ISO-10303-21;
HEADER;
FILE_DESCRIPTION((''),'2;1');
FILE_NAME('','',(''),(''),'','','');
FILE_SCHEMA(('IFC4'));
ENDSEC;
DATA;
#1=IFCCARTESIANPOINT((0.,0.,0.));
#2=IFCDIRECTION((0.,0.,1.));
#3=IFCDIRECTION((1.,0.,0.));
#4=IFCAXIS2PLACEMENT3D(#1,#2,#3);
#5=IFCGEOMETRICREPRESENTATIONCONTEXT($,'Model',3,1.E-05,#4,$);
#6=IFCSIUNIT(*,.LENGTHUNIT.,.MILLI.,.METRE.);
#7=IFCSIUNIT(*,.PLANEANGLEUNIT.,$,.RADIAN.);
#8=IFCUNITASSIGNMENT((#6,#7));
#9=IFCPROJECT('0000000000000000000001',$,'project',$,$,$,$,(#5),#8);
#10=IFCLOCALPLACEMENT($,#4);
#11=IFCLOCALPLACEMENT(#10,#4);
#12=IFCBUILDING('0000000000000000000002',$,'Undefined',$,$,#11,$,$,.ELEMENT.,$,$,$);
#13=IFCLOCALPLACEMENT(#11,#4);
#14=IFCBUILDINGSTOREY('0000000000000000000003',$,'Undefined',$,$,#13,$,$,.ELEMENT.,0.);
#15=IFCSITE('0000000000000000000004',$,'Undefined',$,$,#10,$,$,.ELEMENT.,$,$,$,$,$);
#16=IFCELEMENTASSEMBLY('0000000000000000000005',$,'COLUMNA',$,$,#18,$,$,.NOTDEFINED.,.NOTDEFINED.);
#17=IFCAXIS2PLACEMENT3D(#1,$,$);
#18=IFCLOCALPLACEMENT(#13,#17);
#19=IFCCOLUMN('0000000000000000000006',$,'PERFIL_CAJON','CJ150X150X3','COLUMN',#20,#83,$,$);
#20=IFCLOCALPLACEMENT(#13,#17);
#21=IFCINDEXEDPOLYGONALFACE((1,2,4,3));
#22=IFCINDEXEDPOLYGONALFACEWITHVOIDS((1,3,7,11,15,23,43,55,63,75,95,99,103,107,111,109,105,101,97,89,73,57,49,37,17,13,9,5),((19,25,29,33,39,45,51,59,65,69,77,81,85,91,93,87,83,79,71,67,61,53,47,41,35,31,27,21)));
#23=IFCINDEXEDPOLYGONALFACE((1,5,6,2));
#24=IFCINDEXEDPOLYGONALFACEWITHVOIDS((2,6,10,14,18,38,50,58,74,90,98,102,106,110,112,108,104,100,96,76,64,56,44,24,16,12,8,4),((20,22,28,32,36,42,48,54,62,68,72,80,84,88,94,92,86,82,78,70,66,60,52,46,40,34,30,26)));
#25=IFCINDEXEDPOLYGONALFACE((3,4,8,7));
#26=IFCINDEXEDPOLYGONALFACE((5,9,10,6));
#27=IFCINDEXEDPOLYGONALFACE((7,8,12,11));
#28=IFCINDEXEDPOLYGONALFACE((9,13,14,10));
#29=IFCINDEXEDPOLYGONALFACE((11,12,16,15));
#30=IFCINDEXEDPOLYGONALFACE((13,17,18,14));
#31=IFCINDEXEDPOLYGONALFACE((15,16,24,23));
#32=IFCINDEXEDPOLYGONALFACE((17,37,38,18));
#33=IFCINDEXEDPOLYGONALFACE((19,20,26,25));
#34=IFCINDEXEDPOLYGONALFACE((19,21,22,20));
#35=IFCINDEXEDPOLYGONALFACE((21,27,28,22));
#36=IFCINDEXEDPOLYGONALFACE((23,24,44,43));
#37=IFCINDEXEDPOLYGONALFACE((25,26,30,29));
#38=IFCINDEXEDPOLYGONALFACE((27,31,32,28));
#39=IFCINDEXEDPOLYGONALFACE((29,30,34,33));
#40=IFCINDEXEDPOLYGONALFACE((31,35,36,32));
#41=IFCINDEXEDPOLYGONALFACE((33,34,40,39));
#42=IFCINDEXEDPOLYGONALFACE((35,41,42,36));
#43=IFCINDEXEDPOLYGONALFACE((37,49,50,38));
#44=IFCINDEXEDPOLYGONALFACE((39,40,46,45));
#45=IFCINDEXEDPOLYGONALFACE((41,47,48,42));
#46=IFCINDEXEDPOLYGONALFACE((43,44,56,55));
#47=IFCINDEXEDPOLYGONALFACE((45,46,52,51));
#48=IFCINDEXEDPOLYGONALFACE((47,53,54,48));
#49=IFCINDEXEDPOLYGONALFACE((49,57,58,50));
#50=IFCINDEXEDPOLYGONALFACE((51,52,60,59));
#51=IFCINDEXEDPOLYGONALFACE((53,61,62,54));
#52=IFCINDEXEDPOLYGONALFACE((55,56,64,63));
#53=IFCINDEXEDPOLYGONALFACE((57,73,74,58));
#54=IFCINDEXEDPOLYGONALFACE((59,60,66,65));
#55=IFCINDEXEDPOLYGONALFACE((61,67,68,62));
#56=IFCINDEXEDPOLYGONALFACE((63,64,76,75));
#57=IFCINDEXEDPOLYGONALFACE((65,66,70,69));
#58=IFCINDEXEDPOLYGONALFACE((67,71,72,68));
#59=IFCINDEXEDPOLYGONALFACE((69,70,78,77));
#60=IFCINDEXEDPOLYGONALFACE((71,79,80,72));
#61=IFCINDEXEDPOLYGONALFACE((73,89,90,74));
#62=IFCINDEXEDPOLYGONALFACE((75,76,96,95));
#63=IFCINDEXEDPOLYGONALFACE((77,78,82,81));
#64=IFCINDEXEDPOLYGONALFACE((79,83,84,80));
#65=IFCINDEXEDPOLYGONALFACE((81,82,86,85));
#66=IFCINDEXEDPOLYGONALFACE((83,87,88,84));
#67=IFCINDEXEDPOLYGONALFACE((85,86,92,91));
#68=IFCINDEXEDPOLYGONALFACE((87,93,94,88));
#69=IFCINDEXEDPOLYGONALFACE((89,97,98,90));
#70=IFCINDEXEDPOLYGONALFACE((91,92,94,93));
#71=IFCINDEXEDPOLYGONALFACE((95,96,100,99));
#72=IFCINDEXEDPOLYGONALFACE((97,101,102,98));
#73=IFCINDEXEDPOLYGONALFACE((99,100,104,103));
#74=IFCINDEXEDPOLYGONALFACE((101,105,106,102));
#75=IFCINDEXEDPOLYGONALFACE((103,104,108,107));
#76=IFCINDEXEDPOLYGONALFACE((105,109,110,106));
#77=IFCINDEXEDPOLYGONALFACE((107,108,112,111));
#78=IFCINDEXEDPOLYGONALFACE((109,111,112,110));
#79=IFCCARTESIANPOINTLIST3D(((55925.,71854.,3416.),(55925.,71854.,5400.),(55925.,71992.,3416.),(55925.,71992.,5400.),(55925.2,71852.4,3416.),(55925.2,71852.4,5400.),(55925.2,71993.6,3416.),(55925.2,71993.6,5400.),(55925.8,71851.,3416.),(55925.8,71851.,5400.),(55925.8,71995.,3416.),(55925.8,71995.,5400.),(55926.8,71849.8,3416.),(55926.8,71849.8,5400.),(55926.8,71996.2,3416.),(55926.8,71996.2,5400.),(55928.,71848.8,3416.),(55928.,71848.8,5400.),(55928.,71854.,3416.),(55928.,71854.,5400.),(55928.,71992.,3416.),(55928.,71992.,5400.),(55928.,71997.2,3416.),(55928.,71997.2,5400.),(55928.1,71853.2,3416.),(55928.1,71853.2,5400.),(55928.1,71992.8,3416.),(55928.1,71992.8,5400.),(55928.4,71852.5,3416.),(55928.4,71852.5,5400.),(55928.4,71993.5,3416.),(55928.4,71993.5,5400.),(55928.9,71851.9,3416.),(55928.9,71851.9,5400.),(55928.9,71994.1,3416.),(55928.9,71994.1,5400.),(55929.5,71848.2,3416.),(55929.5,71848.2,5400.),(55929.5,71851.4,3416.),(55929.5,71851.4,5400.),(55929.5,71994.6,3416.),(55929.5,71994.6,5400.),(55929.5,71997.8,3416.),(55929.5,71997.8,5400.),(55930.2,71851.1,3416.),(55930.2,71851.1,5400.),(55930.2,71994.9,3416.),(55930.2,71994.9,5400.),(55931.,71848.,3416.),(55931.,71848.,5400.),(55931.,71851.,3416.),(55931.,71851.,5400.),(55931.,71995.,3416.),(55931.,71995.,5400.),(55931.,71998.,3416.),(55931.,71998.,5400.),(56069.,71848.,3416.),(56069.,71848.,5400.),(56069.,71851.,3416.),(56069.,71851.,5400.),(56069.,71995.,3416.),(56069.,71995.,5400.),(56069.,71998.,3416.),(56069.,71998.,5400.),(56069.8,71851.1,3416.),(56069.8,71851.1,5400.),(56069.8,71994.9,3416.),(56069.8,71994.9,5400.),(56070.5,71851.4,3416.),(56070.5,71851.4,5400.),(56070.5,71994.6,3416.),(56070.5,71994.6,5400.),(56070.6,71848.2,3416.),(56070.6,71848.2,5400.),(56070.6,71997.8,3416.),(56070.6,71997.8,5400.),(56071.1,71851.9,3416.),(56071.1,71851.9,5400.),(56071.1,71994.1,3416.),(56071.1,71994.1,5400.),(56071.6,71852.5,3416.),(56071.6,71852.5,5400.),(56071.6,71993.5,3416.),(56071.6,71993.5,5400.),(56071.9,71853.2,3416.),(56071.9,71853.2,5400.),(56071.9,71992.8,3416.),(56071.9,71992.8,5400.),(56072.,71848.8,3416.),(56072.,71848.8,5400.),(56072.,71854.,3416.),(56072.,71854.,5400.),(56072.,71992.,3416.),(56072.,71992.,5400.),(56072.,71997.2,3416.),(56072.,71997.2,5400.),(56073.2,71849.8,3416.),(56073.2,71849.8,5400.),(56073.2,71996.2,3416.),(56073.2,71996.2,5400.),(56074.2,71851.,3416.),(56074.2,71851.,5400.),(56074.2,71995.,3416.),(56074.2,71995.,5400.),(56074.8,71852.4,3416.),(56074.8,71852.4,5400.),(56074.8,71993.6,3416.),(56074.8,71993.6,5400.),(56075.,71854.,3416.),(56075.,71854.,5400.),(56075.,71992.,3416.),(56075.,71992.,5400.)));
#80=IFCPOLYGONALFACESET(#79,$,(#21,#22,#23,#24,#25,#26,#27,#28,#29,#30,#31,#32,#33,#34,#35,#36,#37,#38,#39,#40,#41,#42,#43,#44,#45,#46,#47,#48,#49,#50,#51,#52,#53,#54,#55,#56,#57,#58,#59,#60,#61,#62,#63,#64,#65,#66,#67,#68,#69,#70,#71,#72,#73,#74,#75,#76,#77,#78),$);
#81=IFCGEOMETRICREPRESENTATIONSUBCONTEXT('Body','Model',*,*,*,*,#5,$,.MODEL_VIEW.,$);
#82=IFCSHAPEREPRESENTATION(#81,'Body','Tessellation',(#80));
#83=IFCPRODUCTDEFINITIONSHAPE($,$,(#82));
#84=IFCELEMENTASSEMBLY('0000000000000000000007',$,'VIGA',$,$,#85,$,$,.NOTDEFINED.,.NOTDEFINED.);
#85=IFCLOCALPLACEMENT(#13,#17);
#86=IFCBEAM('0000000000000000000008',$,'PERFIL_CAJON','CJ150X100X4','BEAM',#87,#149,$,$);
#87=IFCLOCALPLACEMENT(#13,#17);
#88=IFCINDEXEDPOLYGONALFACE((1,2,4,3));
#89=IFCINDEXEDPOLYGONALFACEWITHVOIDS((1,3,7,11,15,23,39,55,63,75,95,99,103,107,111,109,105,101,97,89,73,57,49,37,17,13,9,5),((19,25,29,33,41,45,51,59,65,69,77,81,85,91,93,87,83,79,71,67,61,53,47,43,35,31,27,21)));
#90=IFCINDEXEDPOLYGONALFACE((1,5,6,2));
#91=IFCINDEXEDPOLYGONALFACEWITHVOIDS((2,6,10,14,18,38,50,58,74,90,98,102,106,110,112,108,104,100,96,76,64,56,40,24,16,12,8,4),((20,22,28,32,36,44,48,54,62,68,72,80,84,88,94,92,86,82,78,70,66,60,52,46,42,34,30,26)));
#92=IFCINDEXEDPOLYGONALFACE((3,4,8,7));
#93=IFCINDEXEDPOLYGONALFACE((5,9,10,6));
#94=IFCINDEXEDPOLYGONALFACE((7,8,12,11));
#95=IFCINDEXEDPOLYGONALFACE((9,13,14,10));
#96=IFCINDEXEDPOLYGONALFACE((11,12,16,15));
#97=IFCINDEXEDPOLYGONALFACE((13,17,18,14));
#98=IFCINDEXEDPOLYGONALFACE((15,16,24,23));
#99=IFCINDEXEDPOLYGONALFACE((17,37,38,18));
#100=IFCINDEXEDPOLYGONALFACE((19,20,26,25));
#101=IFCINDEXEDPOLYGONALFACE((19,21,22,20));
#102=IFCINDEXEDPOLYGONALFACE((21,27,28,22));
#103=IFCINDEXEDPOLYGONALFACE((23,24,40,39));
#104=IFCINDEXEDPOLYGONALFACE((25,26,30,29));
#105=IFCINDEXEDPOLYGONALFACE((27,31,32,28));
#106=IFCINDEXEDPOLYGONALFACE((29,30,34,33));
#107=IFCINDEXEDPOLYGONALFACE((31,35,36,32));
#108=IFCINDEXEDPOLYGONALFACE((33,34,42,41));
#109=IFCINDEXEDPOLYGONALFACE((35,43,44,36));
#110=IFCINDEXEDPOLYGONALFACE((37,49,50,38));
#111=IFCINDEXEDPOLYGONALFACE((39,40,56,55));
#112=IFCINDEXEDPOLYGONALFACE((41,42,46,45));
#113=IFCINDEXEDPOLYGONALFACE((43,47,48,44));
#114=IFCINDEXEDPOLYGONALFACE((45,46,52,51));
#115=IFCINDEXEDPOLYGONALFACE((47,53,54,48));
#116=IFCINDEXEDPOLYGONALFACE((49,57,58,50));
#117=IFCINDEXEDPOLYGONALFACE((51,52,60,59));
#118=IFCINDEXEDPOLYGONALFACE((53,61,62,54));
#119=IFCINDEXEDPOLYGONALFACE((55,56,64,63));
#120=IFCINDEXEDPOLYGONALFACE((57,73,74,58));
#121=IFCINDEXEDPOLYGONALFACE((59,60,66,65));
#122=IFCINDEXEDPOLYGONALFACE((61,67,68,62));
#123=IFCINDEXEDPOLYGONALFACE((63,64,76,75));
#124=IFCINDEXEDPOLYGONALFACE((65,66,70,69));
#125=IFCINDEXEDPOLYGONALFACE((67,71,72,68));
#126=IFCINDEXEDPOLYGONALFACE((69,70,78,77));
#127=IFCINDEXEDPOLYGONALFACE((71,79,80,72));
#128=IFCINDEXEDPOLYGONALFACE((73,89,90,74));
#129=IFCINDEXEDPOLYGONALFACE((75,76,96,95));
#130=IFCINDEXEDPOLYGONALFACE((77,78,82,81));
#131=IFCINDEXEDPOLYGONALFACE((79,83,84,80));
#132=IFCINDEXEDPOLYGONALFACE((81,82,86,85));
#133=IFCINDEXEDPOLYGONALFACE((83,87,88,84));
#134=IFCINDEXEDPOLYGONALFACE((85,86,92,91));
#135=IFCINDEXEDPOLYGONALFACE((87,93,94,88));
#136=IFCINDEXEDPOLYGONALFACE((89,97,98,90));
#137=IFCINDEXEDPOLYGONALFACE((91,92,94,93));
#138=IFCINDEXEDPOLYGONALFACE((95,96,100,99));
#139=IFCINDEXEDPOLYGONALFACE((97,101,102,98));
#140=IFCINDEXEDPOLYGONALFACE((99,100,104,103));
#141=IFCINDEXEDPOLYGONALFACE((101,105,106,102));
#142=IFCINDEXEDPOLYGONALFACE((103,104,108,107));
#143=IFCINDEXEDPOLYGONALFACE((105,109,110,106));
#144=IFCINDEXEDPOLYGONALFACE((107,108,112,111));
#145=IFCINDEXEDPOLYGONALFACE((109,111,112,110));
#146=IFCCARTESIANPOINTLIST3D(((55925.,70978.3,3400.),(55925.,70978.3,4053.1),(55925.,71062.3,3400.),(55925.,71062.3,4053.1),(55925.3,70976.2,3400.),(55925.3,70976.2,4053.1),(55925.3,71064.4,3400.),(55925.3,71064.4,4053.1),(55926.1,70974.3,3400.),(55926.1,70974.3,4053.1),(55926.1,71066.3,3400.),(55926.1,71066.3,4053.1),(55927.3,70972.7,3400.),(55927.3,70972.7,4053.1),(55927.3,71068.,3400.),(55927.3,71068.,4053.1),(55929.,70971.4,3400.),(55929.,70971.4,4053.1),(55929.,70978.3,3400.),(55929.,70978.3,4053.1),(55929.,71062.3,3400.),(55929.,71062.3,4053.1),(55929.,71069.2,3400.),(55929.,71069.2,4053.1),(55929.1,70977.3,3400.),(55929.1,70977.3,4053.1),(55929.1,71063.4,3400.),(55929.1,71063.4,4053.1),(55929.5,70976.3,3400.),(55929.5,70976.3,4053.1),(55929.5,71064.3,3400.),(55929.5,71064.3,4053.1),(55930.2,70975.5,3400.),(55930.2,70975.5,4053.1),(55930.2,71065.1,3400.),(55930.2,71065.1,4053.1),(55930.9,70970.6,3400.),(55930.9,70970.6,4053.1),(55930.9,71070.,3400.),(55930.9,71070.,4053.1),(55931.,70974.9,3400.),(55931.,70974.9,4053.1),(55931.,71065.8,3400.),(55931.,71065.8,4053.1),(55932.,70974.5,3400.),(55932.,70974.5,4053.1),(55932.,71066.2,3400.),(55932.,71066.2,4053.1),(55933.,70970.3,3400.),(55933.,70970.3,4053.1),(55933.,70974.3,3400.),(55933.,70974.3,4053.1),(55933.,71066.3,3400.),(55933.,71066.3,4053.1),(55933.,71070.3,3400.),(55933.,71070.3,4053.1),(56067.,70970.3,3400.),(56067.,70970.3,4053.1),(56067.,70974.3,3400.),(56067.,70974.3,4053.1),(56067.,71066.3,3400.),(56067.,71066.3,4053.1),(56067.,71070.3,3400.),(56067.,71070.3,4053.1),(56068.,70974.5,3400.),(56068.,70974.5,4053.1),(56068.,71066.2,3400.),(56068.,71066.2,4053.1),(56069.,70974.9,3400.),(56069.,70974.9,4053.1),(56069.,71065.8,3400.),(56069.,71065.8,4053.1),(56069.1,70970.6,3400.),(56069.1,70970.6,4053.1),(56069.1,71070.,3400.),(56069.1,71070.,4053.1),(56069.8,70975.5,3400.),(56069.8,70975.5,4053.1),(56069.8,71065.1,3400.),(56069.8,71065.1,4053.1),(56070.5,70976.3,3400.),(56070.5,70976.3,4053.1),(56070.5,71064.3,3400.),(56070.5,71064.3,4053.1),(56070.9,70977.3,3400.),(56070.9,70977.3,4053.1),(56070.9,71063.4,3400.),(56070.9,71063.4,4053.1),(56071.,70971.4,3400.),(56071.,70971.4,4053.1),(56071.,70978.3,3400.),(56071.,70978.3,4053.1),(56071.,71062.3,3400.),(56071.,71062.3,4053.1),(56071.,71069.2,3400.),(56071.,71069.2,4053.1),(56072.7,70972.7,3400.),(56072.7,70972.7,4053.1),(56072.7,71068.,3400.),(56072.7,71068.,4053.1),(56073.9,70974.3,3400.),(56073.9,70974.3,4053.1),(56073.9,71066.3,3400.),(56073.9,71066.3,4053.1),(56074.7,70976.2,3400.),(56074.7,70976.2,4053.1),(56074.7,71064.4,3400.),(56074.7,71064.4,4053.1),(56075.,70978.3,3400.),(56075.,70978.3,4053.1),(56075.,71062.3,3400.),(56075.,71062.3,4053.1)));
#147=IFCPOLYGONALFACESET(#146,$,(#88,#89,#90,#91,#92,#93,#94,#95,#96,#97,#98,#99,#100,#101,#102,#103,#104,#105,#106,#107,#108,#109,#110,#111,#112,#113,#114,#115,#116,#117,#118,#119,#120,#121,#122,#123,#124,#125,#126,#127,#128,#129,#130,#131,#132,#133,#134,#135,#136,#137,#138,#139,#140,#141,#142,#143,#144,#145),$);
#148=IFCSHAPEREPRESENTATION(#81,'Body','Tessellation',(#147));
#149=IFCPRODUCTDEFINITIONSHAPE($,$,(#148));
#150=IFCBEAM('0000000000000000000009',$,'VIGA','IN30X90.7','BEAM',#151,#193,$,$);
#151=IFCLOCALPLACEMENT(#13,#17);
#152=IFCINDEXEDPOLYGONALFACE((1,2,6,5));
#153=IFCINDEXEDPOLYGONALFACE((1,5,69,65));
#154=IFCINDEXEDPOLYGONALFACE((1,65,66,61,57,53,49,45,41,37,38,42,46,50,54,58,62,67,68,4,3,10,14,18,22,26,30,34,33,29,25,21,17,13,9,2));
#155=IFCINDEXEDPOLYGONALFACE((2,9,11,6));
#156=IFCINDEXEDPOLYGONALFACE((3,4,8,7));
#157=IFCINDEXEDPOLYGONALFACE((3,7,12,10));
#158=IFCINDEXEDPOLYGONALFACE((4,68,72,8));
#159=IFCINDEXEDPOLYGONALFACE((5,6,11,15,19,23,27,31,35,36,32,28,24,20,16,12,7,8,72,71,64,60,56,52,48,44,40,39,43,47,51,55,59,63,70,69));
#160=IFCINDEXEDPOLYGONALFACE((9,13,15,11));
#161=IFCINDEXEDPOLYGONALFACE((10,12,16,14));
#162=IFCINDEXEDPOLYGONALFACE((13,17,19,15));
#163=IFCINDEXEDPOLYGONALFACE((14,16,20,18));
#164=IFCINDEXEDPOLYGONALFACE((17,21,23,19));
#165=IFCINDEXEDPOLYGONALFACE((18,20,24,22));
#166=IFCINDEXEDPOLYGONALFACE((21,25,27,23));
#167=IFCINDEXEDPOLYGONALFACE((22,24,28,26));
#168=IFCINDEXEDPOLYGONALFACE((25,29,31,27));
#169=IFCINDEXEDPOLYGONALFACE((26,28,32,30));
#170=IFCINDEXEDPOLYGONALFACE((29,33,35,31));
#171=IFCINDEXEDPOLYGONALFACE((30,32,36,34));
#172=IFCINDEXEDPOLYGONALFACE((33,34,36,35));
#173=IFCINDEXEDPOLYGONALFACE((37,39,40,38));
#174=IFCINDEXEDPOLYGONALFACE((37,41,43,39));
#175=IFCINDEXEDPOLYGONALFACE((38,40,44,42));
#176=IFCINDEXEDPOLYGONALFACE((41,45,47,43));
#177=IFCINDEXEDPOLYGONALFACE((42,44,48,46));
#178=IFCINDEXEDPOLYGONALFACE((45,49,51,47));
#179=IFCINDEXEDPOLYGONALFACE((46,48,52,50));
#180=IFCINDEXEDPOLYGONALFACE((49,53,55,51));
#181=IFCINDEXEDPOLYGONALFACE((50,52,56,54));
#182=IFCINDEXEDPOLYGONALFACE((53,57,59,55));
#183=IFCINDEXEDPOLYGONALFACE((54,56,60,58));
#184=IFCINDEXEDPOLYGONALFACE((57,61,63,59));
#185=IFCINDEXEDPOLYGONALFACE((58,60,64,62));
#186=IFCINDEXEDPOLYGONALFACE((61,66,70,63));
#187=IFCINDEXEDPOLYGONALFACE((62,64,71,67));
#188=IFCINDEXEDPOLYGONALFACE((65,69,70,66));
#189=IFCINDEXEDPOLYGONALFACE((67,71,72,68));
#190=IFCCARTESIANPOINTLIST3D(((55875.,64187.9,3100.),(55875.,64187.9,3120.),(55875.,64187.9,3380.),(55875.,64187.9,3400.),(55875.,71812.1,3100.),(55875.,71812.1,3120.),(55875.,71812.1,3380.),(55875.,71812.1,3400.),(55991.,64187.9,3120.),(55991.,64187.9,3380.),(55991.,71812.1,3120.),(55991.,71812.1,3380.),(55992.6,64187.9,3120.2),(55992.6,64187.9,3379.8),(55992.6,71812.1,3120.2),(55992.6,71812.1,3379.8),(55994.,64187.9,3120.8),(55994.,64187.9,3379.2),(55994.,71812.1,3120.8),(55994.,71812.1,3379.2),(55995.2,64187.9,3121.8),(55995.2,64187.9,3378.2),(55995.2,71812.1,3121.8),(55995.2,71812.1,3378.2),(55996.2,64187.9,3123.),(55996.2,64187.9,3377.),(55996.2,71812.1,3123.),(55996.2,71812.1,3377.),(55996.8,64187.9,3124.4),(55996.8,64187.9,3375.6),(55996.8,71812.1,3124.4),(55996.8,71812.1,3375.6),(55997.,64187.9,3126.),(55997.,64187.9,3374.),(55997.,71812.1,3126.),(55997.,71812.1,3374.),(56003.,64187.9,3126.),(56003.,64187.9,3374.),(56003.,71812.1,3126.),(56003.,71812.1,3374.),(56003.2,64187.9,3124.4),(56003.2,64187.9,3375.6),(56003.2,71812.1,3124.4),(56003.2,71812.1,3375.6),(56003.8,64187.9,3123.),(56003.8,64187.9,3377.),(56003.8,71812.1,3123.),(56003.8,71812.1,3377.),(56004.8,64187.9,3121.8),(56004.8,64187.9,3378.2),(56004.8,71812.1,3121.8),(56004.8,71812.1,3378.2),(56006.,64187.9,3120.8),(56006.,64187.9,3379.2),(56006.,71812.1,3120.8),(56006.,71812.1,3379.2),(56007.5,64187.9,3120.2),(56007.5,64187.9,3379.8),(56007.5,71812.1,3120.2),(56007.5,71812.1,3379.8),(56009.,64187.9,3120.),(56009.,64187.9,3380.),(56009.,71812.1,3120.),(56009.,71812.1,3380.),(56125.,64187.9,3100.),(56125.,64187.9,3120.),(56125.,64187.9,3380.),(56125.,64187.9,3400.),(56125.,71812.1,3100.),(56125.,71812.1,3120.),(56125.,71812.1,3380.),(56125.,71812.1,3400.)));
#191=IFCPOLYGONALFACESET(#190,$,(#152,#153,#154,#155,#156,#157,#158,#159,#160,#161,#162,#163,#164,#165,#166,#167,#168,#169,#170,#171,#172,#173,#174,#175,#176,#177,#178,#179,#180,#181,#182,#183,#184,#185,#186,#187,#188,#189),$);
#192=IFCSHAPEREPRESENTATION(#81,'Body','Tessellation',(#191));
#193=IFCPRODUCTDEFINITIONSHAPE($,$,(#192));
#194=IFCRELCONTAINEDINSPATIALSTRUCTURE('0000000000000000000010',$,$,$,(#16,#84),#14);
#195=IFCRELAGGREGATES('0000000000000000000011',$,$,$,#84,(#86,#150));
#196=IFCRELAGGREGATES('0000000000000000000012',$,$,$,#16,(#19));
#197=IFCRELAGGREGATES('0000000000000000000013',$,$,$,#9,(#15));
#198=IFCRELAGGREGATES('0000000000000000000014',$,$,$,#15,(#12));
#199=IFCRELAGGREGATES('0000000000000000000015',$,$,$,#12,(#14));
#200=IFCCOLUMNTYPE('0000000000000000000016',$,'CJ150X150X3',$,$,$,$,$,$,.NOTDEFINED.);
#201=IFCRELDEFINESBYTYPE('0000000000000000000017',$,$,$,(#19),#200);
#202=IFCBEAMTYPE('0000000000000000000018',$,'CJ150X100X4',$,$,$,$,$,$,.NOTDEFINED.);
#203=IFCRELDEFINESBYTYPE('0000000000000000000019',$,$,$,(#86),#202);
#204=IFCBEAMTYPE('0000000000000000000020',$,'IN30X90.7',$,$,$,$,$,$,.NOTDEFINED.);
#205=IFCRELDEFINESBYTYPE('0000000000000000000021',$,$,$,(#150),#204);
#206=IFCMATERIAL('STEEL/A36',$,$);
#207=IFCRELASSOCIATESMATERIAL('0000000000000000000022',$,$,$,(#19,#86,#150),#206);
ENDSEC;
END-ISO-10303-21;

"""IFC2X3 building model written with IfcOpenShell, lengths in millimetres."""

from ifc_helpers import new_model, si_unit, frame, origin_with_axes, origin_2d_with_axis, place, context, subcontext, project, spatial, hollow_rectangle, i_section, extrude, material, type_object, element, aggregate, save


model = new_model("IFC2X3")

# Units and contexts
model_context = context("Model", 3, precision=1e-05, world=origin_with_axes())
body_context = subcontext(model_context, "Body", "Model", "MODEL_VIEW")
ifc_project = project(units=[si_unit("LENGTHUNIT", "METRE", prefix="MILLI"), si_unit("PLANEANGLEUNIT", "RADIAN")], contexts=[model_context])

# Site, building, storey
site_placement = place(None, origin_with_axes())
site = spatial("IfcSite", under=ifc_project, at=site_placement, Name="Undefined", CompositionType="ELEMENT")
building_placement = place(site_placement, origin_with_axes())
building = spatial("IfcBuilding", under=site, at=building_placement, Name="Undefined", CompositionType="ELEMENT")
storey_placement = place(building_placement, origin_with_axes())
storey = spatial("IfcBuildingStorey", under=building, at=storey_placement, Name="Undefined", CompositionType="ELEMENT", Elevation=0.0)

# Element assembly, column
assembly_1_placement = place(storey_placement, origin_with_axes())
assembly_1 = element("IfcElementAssembly", 1, at=assembly_1_placement, inside=storey, Name="COLUMNA", AssemblyPlace="NOTDEFINED", PredefinedType="NOTDEFINED")
ifc_material_1 = material(Name="STEEL/A36")
column_type = type_object("IfcColumnType", Name="CJ150X150X3", PredefinedType="NOTDEFINED")
column_placement = place(assembly_1_placement, frame((56000.0, 71923.0, 3416.0), z_axis=(0.0, 0.0, 1.0), x_axis=(-1.0, 0.0, 0.0)))
column = element("IfcColumn", 2, at=column_placement, type_object=column_type, material=ifc_material_1, Name="PERFIL_CAJON", Description="CJ150X150X3", ObjectType="COLUMN", context=body_context, shape_type="SweptSolid", body=[
    extrude(hollow_rectangle(XDim=150.0, YDim=150.0, WallThickness=3.0, InnerFilletRadius=3.0, OuterFilletRadius=6.0, at=origin_2d_with_axis()), frame((0.0, 0.0, 1984.0), z_axis=(0.0, 0.0, -1.0), x_axis=(0.0, 1.0, 0.0)), (0.0, 0.0, 1.0), 1984.0),
])

# Element assembly, beams
assembly_2_placement = place(storey_placement, origin_with_axes())
assembly_2 = element("IfcElementAssembly", 3, at=assembly_2_placement, inside=storey, Name="VIGA", AssemblyPlace="NOTDEFINED", PredefinedType="NOTDEFINED")
beam_type_1 = type_object("IfcBeamType", Name="CJ150X100X4", PredefinedType="NOTDEFINED")
beam_1_placement = place(assembly_2_placement, frame((56000.0, 71020.3, 4053.1), z_axis=(-1.0, 0.0, 0.0), x_axis=(0.0, 0.0, -1.0)))
beam_1 = element("IfcBeam", 4, at=beam_1_placement, type_object=beam_type_1, material=ifc_material_1, Name="PERFIL_CAJON", Description="CJ150X100X4", ObjectType="BEAM", context=body_context, shape_type="SweptSolid", body=[
    extrude(hollow_rectangle(XDim=100.0, YDim=150.0, WallThickness=4.0, InnerFilletRadius=4.0, OuterFilletRadius=8.0, at=origin_2d_with_axis()), frame((653.1, 0.0, 0.0), z_axis=(-1.0, 0.0, 0.0), x_axis=(0.0, -1.0, 0.0)), (0.0, 0.0, 1.0), 653.1),
])
beam_type_2 = type_object("IfcBeamType", Name="IN30X90.7", PredefinedType="NOTDEFINED")
beam_2_placement = place(assembly_2_placement, frame((56000.0, 71812.1, 3250.0), z_axis=(0.0, 0.0, 1.0), x_axis=(0.0, -1.0, 0.0)))
beam_2 = element("IfcBeam", 5, at=beam_2_placement, type_object=beam_type_2, material=ifc_material_1, Name="VIGA", Description="IN30X90.7", ObjectType="BEAM", context=body_context, shape_type="SweptSolid", body=[
    extrude(i_section(OverallWidth=250.0, OverallDepth=300.0, WebThickness=6.0, FlangeThickness=20.0, FilletRadius=6.0, at=origin_2d_with_axis()), frame((7624.2, 0.0, 0.0), z_axis=(-1.0, 0.0, 0.0), x_axis=(0.0, -1.0, 0.0)), (0.0, 0.0, 1.0), 7624.2),
])

aggregate(assembly_2, [beam_1, beam_2])

aggregate(assembly_1, [column])

save(model, "model.ifc")
